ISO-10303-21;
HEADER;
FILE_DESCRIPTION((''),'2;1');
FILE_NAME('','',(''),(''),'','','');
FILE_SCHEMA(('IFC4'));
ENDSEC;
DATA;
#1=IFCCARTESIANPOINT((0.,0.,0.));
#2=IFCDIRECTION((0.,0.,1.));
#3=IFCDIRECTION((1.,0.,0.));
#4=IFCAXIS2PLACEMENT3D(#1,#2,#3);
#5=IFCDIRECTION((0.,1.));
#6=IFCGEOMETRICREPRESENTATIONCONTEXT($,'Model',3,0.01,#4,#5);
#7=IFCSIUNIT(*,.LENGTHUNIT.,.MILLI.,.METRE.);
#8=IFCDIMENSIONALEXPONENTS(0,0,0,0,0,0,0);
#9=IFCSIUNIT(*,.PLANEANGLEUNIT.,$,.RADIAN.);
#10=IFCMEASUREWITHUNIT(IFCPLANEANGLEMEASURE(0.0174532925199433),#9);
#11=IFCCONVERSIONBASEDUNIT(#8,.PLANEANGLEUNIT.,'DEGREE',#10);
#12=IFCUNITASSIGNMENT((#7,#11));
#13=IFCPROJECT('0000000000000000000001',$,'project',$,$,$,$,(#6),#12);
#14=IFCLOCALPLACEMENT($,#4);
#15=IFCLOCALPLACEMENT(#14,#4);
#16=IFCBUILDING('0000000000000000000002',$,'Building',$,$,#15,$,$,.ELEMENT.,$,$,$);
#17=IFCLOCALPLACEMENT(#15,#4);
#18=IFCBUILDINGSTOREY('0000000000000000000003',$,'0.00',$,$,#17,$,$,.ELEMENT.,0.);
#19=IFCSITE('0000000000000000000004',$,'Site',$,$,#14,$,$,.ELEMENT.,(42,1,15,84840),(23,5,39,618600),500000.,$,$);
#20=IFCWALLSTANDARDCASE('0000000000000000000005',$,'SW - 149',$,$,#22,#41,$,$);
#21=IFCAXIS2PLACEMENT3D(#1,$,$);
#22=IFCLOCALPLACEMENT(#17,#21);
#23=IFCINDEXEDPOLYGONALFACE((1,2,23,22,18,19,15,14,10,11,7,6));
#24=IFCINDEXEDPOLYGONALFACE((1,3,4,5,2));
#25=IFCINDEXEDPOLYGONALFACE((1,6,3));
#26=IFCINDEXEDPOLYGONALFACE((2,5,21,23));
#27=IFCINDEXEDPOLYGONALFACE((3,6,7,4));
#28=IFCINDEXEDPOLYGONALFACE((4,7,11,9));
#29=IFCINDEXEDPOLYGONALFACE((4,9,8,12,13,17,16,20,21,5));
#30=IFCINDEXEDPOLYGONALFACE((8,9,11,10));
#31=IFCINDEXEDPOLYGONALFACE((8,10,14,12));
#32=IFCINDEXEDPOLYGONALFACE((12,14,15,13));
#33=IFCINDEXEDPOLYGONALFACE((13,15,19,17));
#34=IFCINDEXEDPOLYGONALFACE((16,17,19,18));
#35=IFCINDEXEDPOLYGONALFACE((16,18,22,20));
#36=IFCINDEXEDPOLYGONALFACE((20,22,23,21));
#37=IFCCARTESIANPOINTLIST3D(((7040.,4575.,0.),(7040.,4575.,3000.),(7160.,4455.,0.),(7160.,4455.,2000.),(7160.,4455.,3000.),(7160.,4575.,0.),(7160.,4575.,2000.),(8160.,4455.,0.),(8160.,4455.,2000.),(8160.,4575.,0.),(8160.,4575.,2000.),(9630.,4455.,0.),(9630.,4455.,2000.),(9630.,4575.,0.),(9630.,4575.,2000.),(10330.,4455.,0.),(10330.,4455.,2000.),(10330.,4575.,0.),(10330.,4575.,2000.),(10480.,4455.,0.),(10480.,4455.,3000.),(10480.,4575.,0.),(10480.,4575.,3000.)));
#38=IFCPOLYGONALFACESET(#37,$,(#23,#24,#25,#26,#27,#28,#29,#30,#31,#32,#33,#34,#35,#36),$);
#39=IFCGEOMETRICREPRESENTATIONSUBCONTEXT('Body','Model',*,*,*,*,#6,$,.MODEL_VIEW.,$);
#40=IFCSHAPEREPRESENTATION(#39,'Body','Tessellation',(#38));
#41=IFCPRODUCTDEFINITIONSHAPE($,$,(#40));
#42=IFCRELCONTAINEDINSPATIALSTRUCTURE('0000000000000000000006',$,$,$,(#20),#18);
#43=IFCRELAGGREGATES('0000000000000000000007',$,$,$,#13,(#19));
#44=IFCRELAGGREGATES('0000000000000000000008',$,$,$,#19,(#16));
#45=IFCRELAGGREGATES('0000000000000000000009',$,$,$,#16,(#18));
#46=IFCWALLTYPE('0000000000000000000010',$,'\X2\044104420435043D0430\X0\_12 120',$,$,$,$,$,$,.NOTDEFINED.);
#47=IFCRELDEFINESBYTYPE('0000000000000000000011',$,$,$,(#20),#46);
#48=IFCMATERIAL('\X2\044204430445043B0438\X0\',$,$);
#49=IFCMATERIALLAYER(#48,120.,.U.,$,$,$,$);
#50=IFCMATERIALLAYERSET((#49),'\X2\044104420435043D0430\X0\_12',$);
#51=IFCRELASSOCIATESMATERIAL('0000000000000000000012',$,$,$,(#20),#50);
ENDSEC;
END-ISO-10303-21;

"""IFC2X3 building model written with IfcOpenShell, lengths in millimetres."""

from ifc_helpers import new_model, entity, si_unit, converted_unit, direction, frame, origin_with_axes, origin_2d_with_axis, place, context, subcontext, project, spatial, polyline, rectangle, outline, extrude, material, layer, layer_set, layer_usage, type_object, element, save


model = new_model("IFC2X3")

# Units and contexts
model_context = context("Model", 3, precision=0.01, world=origin_with_axes(), true_north=direction((0.0, 1.0)))
body_context = subcontext(model_context, "Body", "Model", "MODEL_VIEW")
ifc_project = project(units=[si_unit("LENGTHUNIT", "METRE", prefix="MILLI"), converted_unit("PLANEANGLEUNIT", "DEGREE", entity("IfcPlaneAngleMeasure", 0.0174532925199433), si_unit("PLANEANGLEUNIT", "RADIAN"), dimensions=[0, 0, 0, 0, 0, 0, 0])], contexts=[model_context])

# Site, building, storey
site_placement = place(None, origin_with_axes())
site = spatial("IfcSite", under=ifc_project, at=site_placement, Name="Site", CompositionType="ELEMENT", RefLatitude=(42, 1, 15, 84840), RefLongitude=(23, 5, 39, 618600), RefElevation=500000.0)
building_placement = place(site_placement, origin_with_axes())
building = spatial("IfcBuilding", under=site, at=building_placement, Name="Building", CompositionType="ELEMENT")
storey_placement = place(building_placement, origin_with_axes())
storey = spatial("IfcBuildingStorey", under=building, at=storey_placement, Name="0.00", CompositionType="ELEMENT", Elevation=0.0)

# Shared definitions
ifc_material_1 = material(Name="тухли")

# Shared definitions
ifc_layer_1 = layer(ifc_material_1, 120.0, ventilated="UNKNOWN")
ifc_layer_set_1 = layer_set([ifc_layer_1], Name="стена_12")
wall_type_1 = type_object("IfcWallType", Name="стена_12 120", PredefinedType="NOTDEFINED")

# Wall, openings
ifc_layer_usage_1 = layer_usage(ifc_layer_set_1, "AXIS2", "NEGATIVE", 0.0)
wall_1_placement = place(storey_placement, frame((7160.0, 4575.0, 0.0), z_axis=(0.0, 0.0, 1.0), x_axis=(1.0, 0.0, 0.0)))
wall_1 = element("IfcWallStandardCase", 1, at=wall_1_placement, inside=storey, type_object=wall_type_1, material=ifc_layer_usage_1, Name="SW - 149", context=body_context, shape_type="SweptSolid", body=[
    extrude(outline(polyline([(0.0, -120.0), (3320.0, -120.0), (3320.0, 0.0), (-120.0, 0.0), (0.0, -120.0)])), origin_with_axes(), (0.0, 0.0, 1.0), 3000.0),
])
opening_1_placement = place(wall_1_placement, frame((500.0, 0.0, 0.0), z_axis=(0.0, 0.0, 1.0), x_axis=(1.0, 0.0, 0.0)))
element("IfcOpeningElement", 2, at=opening_1_placement, cuts=wall_1, context=body_context, shape_type="SweptSolid", body=[
    extrude(rectangle(XDim=1000.0, YDim=2000.0, at=origin_2d_with_axis()), frame((0.0, 120.0, 1000.0), z_axis=(0.0, -1.0, 0.0), x_axis=(-1.0, 0.0, 0.0)), (0.0, 0.0, 1.0), 360.0),
])
opening_2_placement = place(wall_1_placement, frame((2820.0, 0.0, 0.0), z_axis=(0.0, 0.0, 1.0), x_axis=(1.0, 0.0, 0.0)))
element("IfcOpeningElement", 3, at=opening_2_placement, cuts=wall_1, context=body_context, shape_type="SweptSolid", body=[
    extrude(rectangle(XDim=700.0, YDim=2000.0, at=origin_2d_with_axis()), frame((0.0, 120.0, 1000.0), z_axis=(0.0, 1.0, 0.0), x_axis=(1.0, 0.0, 0.0)), (0.0, 0.0, -1.0), 360.0),
])

save(model, "model.ifc")
